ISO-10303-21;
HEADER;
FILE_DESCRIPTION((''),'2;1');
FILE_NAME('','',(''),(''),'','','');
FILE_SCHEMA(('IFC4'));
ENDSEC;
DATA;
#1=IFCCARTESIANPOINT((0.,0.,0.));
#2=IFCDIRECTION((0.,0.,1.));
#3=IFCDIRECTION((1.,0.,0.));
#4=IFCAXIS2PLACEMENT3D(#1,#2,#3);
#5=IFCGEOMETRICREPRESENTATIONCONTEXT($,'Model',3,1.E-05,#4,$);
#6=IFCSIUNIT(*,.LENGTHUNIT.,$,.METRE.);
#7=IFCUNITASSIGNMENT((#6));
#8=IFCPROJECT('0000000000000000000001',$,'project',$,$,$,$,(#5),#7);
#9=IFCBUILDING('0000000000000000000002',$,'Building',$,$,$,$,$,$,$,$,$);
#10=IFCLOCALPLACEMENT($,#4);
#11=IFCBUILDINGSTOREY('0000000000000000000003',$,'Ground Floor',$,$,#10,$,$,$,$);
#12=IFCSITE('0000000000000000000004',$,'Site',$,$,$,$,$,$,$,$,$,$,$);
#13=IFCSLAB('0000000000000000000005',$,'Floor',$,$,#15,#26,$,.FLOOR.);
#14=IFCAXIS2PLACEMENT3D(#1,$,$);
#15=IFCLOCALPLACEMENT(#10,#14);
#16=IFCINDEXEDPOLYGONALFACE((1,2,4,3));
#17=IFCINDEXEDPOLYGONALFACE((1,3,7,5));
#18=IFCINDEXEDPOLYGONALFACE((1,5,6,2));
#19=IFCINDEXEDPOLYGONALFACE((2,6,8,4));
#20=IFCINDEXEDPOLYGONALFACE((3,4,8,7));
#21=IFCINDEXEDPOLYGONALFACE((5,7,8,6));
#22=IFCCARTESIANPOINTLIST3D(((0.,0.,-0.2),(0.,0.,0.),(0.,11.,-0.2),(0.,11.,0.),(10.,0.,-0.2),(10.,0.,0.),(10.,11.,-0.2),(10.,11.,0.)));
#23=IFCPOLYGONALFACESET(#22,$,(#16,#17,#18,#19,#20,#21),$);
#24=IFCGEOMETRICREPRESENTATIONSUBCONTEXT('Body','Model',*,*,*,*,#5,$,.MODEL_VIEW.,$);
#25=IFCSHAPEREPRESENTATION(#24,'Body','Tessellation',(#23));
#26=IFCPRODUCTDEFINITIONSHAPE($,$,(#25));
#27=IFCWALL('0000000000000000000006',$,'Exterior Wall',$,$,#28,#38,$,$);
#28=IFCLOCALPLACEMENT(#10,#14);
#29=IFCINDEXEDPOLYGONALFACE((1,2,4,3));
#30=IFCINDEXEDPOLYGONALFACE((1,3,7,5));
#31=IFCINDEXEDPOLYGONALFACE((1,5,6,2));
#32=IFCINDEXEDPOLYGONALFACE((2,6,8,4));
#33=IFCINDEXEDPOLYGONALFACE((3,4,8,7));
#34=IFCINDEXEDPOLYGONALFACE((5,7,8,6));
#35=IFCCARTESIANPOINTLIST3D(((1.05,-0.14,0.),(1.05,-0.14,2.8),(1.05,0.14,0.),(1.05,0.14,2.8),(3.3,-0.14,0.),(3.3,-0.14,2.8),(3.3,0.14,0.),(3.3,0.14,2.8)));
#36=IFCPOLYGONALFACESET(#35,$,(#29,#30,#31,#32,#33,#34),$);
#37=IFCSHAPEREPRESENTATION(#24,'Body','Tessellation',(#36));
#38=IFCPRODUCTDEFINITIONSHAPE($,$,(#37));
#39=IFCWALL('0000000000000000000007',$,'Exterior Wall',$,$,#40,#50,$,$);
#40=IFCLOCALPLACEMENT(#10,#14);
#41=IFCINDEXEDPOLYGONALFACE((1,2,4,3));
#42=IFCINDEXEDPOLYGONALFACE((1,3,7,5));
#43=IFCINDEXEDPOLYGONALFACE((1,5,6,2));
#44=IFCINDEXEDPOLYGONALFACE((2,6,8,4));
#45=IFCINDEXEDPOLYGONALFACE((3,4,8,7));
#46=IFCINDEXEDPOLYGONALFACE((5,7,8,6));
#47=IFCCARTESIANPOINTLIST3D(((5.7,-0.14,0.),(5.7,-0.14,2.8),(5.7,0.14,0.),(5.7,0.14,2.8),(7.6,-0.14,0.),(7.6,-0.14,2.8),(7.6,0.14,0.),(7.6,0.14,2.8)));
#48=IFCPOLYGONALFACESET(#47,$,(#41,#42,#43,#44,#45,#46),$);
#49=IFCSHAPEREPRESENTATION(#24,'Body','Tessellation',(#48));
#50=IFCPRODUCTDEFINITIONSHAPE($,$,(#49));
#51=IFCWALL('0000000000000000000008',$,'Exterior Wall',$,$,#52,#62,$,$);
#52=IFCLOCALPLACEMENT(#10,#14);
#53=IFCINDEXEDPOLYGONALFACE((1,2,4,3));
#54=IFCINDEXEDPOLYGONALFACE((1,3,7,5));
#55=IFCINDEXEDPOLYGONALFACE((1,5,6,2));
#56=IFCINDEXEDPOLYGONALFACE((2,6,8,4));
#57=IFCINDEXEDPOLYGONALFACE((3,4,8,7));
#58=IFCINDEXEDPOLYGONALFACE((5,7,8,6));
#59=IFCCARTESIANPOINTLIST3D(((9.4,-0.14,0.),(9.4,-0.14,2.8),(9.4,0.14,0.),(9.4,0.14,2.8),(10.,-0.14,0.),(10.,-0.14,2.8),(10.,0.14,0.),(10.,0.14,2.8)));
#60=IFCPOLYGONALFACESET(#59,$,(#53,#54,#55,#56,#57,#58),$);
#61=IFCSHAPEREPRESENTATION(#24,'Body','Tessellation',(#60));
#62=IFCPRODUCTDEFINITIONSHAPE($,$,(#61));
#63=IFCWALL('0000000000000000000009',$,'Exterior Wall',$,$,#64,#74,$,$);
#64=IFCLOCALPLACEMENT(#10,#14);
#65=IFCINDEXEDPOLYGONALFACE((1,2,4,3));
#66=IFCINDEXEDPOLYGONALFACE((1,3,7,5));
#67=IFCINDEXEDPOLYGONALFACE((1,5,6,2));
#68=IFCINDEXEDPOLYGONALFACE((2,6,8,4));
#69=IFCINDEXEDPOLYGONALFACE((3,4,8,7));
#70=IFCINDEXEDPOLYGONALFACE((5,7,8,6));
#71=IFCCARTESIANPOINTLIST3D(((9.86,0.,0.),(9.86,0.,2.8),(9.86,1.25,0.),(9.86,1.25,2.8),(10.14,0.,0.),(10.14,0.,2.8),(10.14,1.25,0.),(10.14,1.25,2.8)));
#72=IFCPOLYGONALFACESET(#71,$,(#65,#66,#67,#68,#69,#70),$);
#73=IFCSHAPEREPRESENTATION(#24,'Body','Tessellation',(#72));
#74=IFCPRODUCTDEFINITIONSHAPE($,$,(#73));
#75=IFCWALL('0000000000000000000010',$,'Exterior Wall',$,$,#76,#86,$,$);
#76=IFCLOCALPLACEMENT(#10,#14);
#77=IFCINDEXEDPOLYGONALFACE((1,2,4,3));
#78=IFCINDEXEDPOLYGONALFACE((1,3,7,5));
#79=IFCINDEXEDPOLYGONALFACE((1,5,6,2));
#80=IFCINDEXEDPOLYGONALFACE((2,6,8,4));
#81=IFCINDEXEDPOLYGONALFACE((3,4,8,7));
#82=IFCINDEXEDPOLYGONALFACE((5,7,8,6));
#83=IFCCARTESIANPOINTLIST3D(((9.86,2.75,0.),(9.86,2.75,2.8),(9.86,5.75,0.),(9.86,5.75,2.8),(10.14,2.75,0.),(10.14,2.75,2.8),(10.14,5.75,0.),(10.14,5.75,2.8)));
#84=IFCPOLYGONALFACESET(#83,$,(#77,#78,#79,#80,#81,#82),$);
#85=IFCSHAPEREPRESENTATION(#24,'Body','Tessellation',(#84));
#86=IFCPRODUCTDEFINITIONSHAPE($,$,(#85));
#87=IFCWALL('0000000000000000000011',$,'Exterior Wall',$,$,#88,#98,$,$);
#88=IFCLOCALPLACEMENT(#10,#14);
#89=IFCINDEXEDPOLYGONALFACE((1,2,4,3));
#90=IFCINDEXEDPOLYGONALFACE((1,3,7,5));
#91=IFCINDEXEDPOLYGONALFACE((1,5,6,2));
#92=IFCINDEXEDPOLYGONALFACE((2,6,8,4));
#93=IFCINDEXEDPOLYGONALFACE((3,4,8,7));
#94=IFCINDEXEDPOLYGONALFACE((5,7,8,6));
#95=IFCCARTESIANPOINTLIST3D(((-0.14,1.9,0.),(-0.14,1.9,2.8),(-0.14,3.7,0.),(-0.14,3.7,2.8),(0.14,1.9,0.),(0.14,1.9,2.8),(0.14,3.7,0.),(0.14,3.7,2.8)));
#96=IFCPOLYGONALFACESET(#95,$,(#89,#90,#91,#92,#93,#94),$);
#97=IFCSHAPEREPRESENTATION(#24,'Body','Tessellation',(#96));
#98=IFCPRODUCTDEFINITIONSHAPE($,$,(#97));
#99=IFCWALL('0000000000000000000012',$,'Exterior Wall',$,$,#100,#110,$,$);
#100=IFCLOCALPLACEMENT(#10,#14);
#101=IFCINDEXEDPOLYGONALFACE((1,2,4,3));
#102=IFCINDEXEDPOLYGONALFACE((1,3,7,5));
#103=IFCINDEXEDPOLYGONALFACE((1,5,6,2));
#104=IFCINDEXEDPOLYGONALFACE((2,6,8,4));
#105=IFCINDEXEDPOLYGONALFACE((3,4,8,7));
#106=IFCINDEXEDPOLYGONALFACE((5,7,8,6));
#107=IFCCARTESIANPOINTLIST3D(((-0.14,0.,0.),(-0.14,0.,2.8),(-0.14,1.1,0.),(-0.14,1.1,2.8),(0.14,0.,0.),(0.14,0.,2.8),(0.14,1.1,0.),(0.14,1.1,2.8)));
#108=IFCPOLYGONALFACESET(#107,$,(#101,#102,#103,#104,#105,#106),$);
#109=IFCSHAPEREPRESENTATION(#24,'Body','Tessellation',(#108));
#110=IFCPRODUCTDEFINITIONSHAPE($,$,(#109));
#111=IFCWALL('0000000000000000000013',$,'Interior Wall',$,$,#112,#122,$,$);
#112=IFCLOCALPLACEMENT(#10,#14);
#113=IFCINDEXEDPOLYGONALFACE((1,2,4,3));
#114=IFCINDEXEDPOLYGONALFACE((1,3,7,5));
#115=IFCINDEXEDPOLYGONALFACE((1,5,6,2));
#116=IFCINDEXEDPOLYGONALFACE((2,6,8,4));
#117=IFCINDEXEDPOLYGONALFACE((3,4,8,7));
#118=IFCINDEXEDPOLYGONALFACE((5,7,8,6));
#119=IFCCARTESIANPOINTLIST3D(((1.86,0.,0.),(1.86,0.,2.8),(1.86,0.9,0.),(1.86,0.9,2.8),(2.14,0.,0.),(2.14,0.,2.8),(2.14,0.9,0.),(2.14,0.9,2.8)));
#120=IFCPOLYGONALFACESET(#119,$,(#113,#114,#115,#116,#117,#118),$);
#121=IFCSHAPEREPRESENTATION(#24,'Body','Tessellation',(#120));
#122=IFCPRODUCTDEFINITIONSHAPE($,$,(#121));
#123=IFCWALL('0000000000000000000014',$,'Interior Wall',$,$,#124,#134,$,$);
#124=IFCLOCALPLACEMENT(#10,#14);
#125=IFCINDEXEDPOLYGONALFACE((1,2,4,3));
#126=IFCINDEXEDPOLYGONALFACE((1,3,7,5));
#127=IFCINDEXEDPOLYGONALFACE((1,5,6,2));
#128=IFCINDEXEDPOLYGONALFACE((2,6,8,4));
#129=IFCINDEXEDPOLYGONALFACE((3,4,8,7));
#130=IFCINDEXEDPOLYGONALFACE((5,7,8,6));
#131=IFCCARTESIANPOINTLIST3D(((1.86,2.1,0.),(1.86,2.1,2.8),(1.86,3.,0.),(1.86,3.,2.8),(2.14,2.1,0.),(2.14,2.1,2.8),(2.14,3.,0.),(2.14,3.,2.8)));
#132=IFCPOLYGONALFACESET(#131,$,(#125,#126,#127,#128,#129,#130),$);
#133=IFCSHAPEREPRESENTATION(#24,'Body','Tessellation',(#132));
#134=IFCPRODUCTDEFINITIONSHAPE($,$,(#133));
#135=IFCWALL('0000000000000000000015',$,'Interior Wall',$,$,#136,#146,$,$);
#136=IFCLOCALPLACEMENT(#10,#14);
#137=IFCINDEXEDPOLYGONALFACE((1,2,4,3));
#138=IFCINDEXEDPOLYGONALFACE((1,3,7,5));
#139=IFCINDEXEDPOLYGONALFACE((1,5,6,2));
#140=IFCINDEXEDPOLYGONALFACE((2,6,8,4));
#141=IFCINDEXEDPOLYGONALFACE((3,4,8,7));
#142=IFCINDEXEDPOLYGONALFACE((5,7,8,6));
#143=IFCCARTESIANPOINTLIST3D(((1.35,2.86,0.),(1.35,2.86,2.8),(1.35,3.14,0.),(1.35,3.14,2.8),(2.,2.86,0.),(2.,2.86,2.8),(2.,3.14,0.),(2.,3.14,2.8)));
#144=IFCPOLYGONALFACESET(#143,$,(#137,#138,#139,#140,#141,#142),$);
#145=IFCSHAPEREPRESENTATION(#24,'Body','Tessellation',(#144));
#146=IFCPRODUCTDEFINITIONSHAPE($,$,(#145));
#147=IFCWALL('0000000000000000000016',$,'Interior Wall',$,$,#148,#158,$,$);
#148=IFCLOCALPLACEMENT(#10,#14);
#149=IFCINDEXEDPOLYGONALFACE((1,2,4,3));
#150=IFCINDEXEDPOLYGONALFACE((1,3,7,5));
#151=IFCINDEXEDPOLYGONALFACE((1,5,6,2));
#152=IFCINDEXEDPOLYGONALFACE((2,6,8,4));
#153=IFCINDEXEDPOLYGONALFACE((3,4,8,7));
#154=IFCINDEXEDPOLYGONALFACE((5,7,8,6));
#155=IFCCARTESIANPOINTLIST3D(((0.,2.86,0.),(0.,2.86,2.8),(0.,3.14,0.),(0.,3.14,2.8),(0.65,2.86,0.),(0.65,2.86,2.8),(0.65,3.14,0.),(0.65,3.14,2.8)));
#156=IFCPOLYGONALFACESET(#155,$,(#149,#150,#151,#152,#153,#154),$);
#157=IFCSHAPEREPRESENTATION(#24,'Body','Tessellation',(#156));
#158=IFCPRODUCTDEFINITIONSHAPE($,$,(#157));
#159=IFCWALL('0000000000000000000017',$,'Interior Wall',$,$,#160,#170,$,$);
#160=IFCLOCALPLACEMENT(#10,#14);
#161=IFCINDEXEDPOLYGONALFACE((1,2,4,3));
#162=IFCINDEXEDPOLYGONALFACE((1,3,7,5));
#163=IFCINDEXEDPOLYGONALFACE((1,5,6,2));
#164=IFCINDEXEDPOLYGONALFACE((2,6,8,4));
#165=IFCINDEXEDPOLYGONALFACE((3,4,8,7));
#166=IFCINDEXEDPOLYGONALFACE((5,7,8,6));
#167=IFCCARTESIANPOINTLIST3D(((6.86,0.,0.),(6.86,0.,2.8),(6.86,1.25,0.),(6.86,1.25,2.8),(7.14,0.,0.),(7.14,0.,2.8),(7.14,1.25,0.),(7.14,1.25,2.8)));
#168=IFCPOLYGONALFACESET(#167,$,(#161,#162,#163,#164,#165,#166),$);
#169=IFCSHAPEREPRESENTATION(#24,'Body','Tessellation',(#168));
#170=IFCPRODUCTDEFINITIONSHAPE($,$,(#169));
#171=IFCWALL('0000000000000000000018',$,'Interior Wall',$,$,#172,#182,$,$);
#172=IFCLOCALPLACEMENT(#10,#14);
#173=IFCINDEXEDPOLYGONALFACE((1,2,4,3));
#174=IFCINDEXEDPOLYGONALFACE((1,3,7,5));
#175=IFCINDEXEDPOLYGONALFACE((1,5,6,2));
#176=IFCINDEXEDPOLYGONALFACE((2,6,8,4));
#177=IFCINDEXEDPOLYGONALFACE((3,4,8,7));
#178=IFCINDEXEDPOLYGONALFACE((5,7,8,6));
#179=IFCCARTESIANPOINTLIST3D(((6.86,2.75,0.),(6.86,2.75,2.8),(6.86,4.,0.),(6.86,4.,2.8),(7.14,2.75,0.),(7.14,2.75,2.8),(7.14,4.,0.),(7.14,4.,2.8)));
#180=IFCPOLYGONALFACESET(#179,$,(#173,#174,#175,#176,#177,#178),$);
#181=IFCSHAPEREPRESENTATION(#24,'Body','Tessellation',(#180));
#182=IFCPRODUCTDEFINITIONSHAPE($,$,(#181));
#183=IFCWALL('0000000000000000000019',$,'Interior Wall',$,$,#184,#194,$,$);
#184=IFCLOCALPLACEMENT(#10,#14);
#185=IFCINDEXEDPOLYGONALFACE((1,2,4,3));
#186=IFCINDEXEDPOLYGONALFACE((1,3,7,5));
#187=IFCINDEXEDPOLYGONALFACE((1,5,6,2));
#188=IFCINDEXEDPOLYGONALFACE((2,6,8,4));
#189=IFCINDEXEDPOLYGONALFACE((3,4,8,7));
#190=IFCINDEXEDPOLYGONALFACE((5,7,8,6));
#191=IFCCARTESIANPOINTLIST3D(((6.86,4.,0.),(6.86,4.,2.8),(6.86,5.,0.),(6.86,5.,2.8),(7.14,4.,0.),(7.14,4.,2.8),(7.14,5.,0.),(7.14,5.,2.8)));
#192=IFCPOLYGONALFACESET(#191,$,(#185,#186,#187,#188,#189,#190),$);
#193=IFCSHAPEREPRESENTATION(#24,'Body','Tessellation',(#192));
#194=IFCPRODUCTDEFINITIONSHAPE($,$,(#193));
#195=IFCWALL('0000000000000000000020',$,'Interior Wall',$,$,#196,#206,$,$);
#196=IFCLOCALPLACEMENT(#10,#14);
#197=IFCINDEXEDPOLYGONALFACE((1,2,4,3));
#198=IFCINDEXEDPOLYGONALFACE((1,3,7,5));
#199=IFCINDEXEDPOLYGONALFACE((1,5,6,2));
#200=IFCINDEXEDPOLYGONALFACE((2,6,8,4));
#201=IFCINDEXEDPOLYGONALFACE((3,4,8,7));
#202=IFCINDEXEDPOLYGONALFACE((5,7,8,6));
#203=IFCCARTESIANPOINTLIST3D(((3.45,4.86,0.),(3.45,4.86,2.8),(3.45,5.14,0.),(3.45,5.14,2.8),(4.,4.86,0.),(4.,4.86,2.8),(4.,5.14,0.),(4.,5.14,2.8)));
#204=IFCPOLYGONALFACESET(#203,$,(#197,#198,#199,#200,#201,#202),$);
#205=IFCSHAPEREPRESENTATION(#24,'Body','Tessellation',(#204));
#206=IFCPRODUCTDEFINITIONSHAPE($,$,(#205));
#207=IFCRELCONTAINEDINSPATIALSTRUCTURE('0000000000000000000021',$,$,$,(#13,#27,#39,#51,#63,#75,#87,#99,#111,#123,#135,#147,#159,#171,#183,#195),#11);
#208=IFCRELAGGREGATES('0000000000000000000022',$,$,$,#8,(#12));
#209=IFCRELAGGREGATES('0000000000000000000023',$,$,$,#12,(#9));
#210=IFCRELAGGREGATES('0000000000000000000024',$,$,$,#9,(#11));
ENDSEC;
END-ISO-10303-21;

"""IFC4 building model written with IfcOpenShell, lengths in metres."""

from ifc_helpers import new_model, si_unit, frame, origin_with_axes, place, context, subcontext, project, spatial, indexed_curve, outline, extrude, element, save


model = new_model("IFC4")

# Units and contexts
model_context = context("Model", 3, precision=1e-05, world=origin_with_axes())
body_context = subcontext(model_context, "Body", "Model", "MODEL_VIEW")
ifc_project = project(units=[si_unit("LENGTHUNIT", "METRE")], contexts=[model_context])

# Site, building, storey
site = spatial("IfcSite", under=ifc_project, Name="Site")
building = spatial("IfcBuilding", under=site, Name="Building")
storey_placement = place(None, origin_with_axes())
storey = spatial("IfcBuildingStorey", under=building, at=storey_placement, Name="Ground Floor")

# Slab
slab_placement = place(storey_placement, frame((0.0, 0.0, -0.2), z_axis=(0.0, 0.0, 1.0), x_axis=(1.0, 0.0, 0.0)))
element("IfcSlab", 1, at=slab_placement, inside=storey, Name="Floor", PredefinedType="FLOOR", context=body_context, shape_type="SweptSolid", body=[
    extrude(outline(indexed_curve([(0.0, 0.0), (10.0, 0.0), (10.0, 11.0), (0.0, 11.0)])), None, (0.0, 0.0, 1.0), 0.2),
])

# Walls
wall_1_placement = place(storey_placement, frame((1.05, 0.0, 0.0), z_axis=(0.0, 0.0, 1.0), x_axis=(1.0, 0.0, 0.0)))
element("IfcWall", 2, at=wall_1_placement, inside=storey, Name="Exterior Wall", context=body_context, shape_type="SweptSolid", body=[
    extrude(outline(indexed_curve([(0.0, 0.0), (0.0, 0.28), (2.25, 0.28), (2.25, 0.0), (0.0, 0.0)], self_intersect=False)), frame((0.0, -0.14, 0.0), z_axis=(0.0, 0.0, 1.0), x_axis=(1.0, 0.0, 0.0)), (0.0, 0.0, 1.0), 2.8),
])
wall_2_placement = place(storey_placement, frame((5.7, 0.0, 0.0), z_axis=(0.0, 0.0, 1.0), x_axis=(1.0, 0.0, 0.0)))
element("IfcWall", 3, at=wall_2_placement, inside=storey, Name="Exterior Wall", context=body_context, shape_type="SweptSolid", body=[
    extrude(outline(indexed_curve([(0.0, 0.0), (0.0, 0.28), (1.9, 0.28), (1.9, 0.0), (0.0, 0.0)], self_intersect=False)), frame((0.0, -0.14, 0.0), z_axis=(0.0, 0.0, 1.0), x_axis=(1.0, 0.0, 0.0)), (0.0, 0.0, 1.0), 2.8),
])
wall_3_placement = place(storey_placement, frame((9.4, 0.0, 0.0), z_axis=(0.0, 0.0, 1.0), x_axis=(1.0, 0.0, 0.0)))
element("IfcWall", 4, at=wall_3_placement, inside=storey, Name="Exterior Wall", context=body_context, shape_type="SweptSolid", body=[
    extrude(outline(indexed_curve([(0.0, 0.0), (0.0, 0.28), (0.6, 0.28), (0.6, 0.0), (0.0, 0.0)], self_intersect=False)), frame((0.0, -0.14, 0.0), z_axis=(0.0, 0.0, 1.0), x_axis=(1.0, 0.0, 0.0)), (0.0, 0.0, 1.0), 2.8),
])
wall_4_placement = place(storey_placement, frame((10.0, 0.0, 0.0), z_axis=(0.0, 0.0, 1.0), x_axis=(0.0, 1.0, 0.0)))
element("IfcWall", 5, at=wall_4_placement, inside=storey, Name="Exterior Wall", context=body_context, shape_type="SweptSolid", body=[
    extrude(outline(indexed_curve([(0.0, 0.0), (0.0, 0.28), (1.25, 0.28), (1.25, 0.0), (0.0, 0.0)], self_intersect=False)), frame((0.0, -0.14, 0.0), z_axis=(0.0, 0.0, 1.0), x_axis=(1.0, 0.0, 0.0)), (0.0, 0.0, 1.0), 2.8),
])
wall_5_placement = place(storey_placement, frame((10.0, 2.75, 0.0), z_axis=(0.0, 0.0, 1.0), x_axis=(0.0, 1.0, 0.0)))
element("IfcWall", 6, at=wall_5_placement, inside=storey, Name="Exterior Wall", context=body_context, shape_type="SweptSolid", body=[
    extrude(outline(indexed_curve([(0.0, 0.0), (0.0, 0.28), (3.0, 0.28), (3.0, 0.0), (0.0, 0.0)], self_intersect=False)), frame((0.0, -0.14, 0.0), z_axis=(0.0, 0.0, 1.0), x_axis=(1.0, 0.0, 0.0)), (0.0, 0.0, 1.0), 2.8),
])
wall_6_placement = place(storey_placement, frame((0.0, 3.7, 0.0), z_axis=(0.0, 0.0, 1.0), x_axis=(0.0, -1.0, 0.0)))
element("IfcWall", 7, at=wall_6_placement, inside=storey, Name="Exterior Wall", context=body_context, shape_type="SweptSolid", body=[
    extrude(outline(indexed_curve([(0.0, 0.0), (0.0, 0.28), (1.8, 0.28), (1.8, 0.0), (0.0, 0.0)], self_intersect=False)), frame((0.0, -0.14, 0.0), z_axis=(0.0, 0.0, 1.0), x_axis=(1.0, 0.0, 0.0)), (0.0, 0.0, 1.0), 2.8),
])
wall_7_placement = place(storey_placement, frame((0.0, 1.1, 0.0), z_axis=(0.0, 0.0, 1.0), x_axis=(0.0, -1.0, 0.0)))
element("IfcWall", 8, at=wall_7_placement, inside=storey, Name="Exterior Wall", context=body_context, shape_type="SweptSolid", body=[
    extrude(outline(indexed_curve([(0.0, 0.0), (0.0, 0.28), (1.1, 0.28), (1.1, 0.0), (0.0, 0.0)], self_intersect=False)), frame((0.0, -0.14, 0.0), z_axis=(0.0, 0.0, 1.0), x_axis=(1.0, 0.0, 0.0)), (0.0, 0.0, 1.0), 2.8),
])
wall_8_placement = place(storey_placement, frame((2.0, 0.0, 0.0), z_axis=(0.0, 0.0, 1.0), x_axis=(0.0, 1.0, 0.0)))
element("IfcWall", 9, at=wall_8_placement, inside=storey, Name="Interior Wall", context=body_context, shape_type="SweptSolid", body=[
    extrude(outline(indexed_curve([(0.0, 0.0), (0.0, 0.28), (0.9, 0.28), (0.9, 0.0), (0.0, 0.0)], self_intersect=False)), frame((0.0, -0.14, 0.0), z_axis=(0.0, 0.0, 1.0), x_axis=(1.0, 0.0, 0.0)), (0.0, 0.0, 1.0), 2.8),
])
wall_9_placement = place(storey_placement, frame((2.0, 2.1, 0.0), z_axis=(0.0, 0.0, 1.0), x_axis=(0.0, 1.0, 0.0)))
element("IfcWall", 10, at=wall_9_placement, inside=storey, Name="Interior Wall", context=body_context, shape_type="SweptSolid", body=[
    extrude(outline(indexed_curve([(0.0, 0.0), (0.0, 0.28), (0.9, 0.28), (0.9, 0.0), (0.0, 0.0)], self_intersect=False)), frame((0.0, -0.14, 0.0), z_axis=(0.0, 0.0, 1.0), x_axis=(1.0, 0.0, 0.0)), (0.0, 0.0, 1.0), 2.8),
])
for number, where, z_axis, x_axis, name in (
    (11, (2.0, 3.0, 0.0), (0.0, 0.0, 1.0), (-1.0, 0.0, 0.0), "Interior Wall"),
    (12, (0.65, 3.0, 0.0), (0.0, 0.0, 1.0), (-1.0, 0.0, 0.0), "Interior Wall"),
):
    element("IfcWall", number, at=place(storey_placement, frame(where, z_axis=z_axis, x_axis=x_axis)), inside=storey, Name=name, context=body_context, shape_type="SweptSolid", body=[
        extrude(outline(indexed_curve([(0.0, 0.0), (0.0, 0.28), (0.65, 0.28), (0.65, 0.0), (0.0, 0.0)], self_intersect=False)), frame((0.0, -0.14, 0.0), z_axis=(0.0, 0.0, 1.0), x_axis=(1.0, 0.0, 0.0)), (0.0, 0.0, 1.0), 2.8),
    ])
for number, where, z_axis, x_axis, name in (
    (13, (7.0, 0.0, 0.0), (0.0, 0.0, 1.0), (0.0, 1.0, 0.0), "Interior Wall"),
    (14, (7.0, 2.75, 0.0), (0.0, 0.0, 1.0), (0.0, 1.0, 0.0), "Interior Wall"),
):
    element("IfcWall", number, at=place(storey_placement, frame(where, z_axis=z_axis, x_axis=x_axis)), inside=storey, Name=name, context=body_context, shape_type="SweptSolid", body=[
        extrude(outline(indexed_curve([(0.0, 0.0), (0.0, 0.28), (1.25, 0.28), (1.25, 0.0), (0.0, 0.0)], self_intersect=False)), frame((0.0, -0.14, 0.0), z_axis=(0.0, 0.0, 1.0), x_axis=(1.0, 0.0, 0.0)), (0.0, 0.0, 1.0), 2.8),
    ])
wall_10_placement = place(storey_placement, frame((7.0, 4.0, 0.0), z_axis=(0.0, 0.0, 1.0), x_axis=(0.0, 1.0, 0.0)))
element("IfcWall", 15, at=wall_10_placement, inside=storey, Name="Interior Wall", context=body_context, shape_type="SweptSolid", body=[
    extrude(outline(indexed_curve([(0.0, 0.0), (0.0, 0.28), (1.0, 0.28), (1.0, 0.0), (0.0, 0.0)], self_intersect=False)), frame((0.0, -0.14, 0.0), z_axis=(0.0, 0.0, 1.0), x_axis=(1.0, 0.0, 0.0)), (0.0, 0.0, 1.0), 2.8),
])
for number, where, z_axis, x_axis, name in (
    (16, (4.0, 5.0, 0.0), (0.0, 0.0, 1.0), (-1.0, 0.0, 0.0), "Interior Wall"),
):
    element("IfcWall", number, at=place(storey_placement, frame(where, z_axis=z_axis, x_axis=x_axis)), inside=storey, Name=name, context=body_context, shape_type="SweptSolid", body=[
        extrude(outline(indexed_curve([(0.0, 0.0), (0.0, 0.28), (0.55, 0.28), (0.55, 0.0), (0.0, 0.0)], self_intersect=False)), frame((0.0, -0.14, 0.0), z_axis=(0.0, 0.0, 1.0), x_axis=(1.0, 0.0, 0.0)), (0.0, 0.0, 1.0), 2.8),
    ])

save(model, "model.ifc")
